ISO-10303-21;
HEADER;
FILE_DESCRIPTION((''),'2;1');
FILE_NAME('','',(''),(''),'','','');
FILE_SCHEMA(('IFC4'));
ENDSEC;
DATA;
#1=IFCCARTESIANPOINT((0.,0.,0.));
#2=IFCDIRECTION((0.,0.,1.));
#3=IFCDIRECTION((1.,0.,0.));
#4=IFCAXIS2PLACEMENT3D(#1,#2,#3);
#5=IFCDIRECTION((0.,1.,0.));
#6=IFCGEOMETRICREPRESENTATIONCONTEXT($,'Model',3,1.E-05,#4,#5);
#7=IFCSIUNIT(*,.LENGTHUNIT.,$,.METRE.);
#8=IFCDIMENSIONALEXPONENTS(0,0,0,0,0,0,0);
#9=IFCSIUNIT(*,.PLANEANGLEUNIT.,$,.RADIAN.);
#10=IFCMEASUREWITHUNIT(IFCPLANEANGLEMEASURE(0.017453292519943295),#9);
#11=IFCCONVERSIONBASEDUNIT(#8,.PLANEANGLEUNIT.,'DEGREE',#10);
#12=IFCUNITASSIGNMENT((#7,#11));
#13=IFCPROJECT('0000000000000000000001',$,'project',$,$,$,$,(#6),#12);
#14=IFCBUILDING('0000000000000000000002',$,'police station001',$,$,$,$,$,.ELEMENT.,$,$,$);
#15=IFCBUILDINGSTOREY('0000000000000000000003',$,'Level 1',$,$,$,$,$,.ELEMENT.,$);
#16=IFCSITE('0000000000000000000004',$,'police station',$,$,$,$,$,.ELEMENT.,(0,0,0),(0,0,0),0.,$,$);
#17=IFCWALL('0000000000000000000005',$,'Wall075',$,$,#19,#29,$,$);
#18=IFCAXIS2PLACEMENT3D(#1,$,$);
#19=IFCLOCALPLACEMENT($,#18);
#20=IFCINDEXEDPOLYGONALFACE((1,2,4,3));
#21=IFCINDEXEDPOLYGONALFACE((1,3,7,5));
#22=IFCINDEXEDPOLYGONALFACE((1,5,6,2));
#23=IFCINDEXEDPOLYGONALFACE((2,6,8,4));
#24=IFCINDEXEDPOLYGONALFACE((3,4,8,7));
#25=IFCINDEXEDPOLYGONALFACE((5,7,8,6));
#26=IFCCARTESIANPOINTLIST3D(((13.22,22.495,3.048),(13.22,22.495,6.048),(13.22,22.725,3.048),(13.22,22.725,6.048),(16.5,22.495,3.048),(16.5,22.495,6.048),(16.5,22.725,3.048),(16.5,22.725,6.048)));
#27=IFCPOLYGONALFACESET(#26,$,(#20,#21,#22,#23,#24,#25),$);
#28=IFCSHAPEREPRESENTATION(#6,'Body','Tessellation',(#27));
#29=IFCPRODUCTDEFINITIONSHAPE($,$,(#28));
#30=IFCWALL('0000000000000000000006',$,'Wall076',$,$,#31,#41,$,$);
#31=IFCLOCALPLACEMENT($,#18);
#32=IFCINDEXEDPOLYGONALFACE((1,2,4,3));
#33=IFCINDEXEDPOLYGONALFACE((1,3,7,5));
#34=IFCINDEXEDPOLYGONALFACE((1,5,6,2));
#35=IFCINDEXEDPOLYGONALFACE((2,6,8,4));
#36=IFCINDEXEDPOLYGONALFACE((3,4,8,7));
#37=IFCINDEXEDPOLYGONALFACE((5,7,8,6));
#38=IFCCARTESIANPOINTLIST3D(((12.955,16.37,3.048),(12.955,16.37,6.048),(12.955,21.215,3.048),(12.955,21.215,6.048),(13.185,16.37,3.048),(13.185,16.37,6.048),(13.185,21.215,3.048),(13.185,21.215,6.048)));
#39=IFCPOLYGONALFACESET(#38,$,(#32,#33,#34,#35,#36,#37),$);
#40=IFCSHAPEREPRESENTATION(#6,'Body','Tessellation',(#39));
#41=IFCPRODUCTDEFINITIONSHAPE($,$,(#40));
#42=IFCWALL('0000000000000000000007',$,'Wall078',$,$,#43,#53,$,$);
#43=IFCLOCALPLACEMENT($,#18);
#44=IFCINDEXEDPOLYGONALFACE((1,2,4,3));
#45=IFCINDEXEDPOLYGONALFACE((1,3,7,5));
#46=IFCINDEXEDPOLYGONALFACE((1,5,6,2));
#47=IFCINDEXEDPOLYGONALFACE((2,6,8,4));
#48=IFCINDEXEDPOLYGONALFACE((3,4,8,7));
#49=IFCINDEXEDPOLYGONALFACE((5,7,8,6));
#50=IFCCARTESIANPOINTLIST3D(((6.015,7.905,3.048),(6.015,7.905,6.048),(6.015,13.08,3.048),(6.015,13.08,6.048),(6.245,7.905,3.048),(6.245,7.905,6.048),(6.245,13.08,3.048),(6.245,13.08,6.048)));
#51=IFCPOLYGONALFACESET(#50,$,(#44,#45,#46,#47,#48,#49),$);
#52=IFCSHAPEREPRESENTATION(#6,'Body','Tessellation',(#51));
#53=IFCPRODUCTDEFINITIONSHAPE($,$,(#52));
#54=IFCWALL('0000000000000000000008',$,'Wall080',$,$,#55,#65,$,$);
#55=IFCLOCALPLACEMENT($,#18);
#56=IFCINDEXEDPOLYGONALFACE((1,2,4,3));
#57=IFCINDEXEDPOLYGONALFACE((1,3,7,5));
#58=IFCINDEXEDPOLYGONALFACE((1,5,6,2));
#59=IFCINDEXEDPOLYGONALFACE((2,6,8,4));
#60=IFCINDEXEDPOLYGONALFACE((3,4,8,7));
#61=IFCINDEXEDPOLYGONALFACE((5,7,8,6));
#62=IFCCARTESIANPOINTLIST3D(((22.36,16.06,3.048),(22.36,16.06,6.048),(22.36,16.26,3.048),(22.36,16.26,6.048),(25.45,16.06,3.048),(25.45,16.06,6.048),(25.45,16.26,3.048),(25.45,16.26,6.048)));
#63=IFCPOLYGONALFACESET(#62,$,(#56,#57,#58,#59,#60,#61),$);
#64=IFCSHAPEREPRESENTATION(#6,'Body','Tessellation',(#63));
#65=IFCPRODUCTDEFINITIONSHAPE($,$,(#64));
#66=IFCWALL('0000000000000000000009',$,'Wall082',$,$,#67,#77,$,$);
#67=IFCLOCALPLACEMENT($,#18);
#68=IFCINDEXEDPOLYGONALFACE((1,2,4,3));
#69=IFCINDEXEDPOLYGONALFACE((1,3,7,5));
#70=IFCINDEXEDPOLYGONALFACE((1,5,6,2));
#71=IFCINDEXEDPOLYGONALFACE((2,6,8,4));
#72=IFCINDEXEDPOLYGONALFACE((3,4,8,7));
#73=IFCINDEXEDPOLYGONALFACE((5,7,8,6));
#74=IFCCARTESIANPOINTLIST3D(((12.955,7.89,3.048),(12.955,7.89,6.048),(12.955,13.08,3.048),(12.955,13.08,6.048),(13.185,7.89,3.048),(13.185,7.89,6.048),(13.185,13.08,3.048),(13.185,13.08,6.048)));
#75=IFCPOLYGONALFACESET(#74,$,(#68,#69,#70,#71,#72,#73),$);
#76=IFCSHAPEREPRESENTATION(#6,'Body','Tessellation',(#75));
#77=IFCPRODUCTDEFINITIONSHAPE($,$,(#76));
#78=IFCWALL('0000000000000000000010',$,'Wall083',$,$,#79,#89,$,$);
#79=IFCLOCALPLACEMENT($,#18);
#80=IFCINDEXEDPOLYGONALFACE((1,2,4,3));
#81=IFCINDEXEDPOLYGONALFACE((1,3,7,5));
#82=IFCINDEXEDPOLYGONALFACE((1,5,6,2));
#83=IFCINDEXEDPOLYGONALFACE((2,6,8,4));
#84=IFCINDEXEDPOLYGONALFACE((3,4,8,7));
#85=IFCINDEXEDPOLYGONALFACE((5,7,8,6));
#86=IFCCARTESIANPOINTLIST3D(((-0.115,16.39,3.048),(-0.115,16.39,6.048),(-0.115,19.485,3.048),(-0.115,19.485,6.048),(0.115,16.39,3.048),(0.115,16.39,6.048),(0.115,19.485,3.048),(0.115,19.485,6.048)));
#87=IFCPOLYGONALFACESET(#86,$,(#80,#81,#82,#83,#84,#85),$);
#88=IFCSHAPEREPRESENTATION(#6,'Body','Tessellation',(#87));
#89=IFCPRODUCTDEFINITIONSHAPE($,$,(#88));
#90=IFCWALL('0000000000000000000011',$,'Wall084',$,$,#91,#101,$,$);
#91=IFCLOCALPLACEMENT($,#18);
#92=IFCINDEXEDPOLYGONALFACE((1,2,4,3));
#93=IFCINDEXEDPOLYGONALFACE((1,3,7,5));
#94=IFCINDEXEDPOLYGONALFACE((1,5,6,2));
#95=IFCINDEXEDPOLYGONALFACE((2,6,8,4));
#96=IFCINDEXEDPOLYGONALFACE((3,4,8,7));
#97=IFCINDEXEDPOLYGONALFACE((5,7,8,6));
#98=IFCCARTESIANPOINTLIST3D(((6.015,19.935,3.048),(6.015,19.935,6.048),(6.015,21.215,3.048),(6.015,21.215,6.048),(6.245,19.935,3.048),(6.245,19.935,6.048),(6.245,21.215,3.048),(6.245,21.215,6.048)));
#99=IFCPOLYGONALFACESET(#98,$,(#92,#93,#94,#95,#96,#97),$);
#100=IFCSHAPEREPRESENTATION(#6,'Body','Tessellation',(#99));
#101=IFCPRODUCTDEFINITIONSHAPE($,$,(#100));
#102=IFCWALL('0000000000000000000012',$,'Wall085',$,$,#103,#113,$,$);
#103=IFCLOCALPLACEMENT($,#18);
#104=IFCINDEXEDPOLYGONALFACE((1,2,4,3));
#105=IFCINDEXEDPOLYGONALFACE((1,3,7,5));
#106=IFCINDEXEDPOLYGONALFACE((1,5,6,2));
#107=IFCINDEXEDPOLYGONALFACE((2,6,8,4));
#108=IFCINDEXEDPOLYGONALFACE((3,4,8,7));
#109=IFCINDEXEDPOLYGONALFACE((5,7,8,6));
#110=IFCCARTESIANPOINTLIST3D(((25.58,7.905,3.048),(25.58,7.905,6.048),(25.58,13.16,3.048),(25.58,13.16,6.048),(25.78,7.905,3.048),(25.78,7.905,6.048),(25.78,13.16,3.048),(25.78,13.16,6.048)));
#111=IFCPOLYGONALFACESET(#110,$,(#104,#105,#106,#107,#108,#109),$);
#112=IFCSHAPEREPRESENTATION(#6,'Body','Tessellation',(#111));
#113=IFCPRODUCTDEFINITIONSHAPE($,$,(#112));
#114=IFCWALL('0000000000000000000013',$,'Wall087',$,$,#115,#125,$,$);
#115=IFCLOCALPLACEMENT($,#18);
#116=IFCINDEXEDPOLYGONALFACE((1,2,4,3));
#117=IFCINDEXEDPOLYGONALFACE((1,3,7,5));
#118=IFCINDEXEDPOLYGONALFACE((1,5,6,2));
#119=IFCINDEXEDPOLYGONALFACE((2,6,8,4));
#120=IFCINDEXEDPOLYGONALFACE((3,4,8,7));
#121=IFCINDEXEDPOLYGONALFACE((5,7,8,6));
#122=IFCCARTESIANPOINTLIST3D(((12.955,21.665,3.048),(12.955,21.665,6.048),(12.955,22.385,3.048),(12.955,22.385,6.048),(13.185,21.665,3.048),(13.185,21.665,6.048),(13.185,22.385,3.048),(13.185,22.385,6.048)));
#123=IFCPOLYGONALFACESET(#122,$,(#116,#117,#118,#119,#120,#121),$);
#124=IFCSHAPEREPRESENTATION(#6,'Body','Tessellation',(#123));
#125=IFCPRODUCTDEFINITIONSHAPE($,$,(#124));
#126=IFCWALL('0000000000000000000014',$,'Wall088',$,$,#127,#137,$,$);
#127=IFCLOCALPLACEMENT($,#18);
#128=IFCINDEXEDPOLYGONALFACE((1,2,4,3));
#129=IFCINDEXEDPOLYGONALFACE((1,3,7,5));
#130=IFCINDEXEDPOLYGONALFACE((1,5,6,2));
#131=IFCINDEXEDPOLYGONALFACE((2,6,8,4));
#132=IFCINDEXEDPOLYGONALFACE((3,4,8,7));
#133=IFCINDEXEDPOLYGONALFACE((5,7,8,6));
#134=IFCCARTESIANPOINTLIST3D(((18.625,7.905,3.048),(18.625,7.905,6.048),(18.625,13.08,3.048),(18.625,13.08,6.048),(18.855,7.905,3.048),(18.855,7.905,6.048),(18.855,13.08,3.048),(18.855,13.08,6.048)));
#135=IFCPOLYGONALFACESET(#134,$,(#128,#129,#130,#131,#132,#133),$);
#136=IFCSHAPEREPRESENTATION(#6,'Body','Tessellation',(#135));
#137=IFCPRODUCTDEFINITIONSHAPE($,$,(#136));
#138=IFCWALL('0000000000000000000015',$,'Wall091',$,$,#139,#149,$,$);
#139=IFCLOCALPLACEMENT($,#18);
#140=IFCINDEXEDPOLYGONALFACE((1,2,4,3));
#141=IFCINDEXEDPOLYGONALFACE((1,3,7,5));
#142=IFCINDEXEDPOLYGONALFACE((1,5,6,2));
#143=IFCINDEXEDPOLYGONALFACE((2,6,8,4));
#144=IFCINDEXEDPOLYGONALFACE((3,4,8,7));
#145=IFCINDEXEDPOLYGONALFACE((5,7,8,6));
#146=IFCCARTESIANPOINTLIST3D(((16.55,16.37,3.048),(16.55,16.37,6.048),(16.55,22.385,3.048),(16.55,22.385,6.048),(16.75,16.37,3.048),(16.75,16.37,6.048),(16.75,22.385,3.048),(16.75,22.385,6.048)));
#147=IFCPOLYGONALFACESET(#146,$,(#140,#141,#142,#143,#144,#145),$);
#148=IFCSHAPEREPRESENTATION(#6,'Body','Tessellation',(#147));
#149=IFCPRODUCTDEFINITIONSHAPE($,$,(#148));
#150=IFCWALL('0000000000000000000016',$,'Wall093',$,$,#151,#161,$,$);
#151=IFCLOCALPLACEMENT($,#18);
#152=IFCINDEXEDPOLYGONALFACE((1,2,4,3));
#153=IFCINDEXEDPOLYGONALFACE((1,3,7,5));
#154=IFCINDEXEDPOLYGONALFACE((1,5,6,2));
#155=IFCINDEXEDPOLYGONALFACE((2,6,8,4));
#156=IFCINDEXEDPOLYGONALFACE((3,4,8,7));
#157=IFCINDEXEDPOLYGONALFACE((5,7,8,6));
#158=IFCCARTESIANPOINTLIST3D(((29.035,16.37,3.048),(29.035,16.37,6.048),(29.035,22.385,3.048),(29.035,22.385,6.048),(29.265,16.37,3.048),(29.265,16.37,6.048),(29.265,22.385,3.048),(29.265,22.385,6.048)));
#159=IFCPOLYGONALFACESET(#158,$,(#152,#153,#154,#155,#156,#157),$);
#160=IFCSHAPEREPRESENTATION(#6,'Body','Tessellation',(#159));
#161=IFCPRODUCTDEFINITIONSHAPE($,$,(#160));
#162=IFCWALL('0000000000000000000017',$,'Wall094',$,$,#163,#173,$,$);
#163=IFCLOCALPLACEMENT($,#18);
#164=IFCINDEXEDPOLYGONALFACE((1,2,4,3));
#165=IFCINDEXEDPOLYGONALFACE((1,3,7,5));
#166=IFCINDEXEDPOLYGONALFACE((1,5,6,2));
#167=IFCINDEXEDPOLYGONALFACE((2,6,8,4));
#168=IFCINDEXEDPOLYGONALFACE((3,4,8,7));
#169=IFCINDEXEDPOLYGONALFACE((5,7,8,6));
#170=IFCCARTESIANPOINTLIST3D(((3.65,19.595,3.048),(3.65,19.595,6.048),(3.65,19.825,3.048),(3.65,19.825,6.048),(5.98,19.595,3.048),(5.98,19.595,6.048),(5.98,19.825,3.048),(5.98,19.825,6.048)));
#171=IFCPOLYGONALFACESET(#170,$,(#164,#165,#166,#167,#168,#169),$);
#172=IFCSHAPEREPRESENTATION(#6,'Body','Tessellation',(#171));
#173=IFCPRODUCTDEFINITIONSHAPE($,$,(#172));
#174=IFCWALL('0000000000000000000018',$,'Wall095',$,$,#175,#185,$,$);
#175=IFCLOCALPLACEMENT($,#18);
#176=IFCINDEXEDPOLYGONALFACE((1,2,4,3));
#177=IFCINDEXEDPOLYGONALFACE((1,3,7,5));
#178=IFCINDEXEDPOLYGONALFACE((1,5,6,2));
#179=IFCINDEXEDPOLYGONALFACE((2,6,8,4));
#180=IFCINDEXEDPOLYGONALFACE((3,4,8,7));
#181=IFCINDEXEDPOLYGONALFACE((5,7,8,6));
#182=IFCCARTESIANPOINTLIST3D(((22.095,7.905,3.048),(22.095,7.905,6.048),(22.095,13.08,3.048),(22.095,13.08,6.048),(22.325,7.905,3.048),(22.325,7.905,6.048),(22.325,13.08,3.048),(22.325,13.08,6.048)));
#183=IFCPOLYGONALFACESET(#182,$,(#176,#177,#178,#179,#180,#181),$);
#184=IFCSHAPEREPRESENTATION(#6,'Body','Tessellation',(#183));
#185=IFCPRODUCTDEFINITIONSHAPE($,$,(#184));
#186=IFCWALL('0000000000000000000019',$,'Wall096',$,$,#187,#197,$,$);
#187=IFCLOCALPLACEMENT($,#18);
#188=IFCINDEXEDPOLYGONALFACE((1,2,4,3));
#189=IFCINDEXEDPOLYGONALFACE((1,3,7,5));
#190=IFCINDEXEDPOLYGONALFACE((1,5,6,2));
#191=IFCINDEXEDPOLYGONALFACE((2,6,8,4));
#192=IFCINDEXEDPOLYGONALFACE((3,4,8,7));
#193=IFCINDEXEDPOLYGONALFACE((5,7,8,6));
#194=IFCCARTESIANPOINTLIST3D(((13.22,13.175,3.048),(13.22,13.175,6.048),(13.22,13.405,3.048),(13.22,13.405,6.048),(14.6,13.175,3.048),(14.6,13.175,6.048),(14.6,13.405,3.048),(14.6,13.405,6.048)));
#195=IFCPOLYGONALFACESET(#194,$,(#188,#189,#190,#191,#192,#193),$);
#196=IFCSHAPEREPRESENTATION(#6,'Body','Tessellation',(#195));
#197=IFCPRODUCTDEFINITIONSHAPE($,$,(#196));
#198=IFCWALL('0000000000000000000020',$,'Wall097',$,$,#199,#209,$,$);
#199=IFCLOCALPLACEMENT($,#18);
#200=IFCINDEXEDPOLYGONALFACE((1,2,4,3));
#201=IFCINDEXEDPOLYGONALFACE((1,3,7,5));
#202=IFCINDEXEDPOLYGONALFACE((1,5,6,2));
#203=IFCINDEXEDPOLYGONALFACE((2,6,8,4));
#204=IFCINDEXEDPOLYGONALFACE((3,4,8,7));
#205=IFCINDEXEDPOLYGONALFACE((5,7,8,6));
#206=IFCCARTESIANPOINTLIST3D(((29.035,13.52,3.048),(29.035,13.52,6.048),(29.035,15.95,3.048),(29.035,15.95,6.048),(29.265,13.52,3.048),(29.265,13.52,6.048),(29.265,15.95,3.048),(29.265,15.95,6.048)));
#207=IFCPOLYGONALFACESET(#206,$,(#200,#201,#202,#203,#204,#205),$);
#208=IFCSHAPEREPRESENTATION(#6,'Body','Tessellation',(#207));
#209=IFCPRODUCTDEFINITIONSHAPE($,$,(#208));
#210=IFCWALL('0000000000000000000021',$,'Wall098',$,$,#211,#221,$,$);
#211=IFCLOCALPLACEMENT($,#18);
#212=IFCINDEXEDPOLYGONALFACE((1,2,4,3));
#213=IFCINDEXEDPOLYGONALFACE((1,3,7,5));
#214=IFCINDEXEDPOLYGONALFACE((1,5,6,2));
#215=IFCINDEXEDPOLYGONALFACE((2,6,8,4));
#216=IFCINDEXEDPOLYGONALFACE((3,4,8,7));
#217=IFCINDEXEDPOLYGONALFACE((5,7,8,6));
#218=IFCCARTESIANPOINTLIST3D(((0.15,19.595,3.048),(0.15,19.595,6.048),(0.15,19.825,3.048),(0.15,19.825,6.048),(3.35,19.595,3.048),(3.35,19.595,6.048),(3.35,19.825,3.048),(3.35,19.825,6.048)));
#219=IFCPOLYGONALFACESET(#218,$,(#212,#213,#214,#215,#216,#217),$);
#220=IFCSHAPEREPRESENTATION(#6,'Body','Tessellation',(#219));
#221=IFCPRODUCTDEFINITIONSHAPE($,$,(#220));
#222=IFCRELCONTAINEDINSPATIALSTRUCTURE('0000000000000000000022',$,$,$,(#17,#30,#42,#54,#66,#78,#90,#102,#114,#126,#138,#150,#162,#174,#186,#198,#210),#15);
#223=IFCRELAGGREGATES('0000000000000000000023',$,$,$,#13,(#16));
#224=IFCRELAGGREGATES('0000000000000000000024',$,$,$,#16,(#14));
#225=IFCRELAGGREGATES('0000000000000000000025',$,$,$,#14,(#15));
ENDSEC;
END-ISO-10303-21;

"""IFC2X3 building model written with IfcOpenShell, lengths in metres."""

from ifc_helpers import new_model, entity, si_unit, converted_unit, direction, frame, frame_2d, origin_with_axes, place, context, project, spatial, rectangle, extrude, element, save


model = new_model("IFC2X3")

# Units and contexts
model_context = context("Model", 3, precision=1e-05, world=origin_with_axes(), true_north=direction((0.0, 1.0, 0.0)))
ifc_project = project(units=[si_unit("LENGTHUNIT", "METRE"), converted_unit("PLANEANGLEUNIT", "DEGREE", entity("IfcPlaneAngleMeasure", 0.017453292519943295), si_unit("PLANEANGLEUNIT", "RADIAN"), dimensions=[0, 0, 0, 0, 0, 0, 0])], contexts=[model_context])

# Site, building, storey
site = spatial("IfcSite", under=ifc_project, Name="police station", CompositionType="ELEMENT", RefLatitude=(0, 0, 0), RefLongitude=(0, 0, 0), RefElevation=0.0)
building = spatial("IfcBuilding", under=site, Name="police station001", CompositionType="ELEMENT")
storey = spatial("IfcBuildingStorey", under=building, Name="Level 1", CompositionType="ELEMENT")

# Shared definitions
placement = place(None, origin_with_axes())

# Walls
element("IfcWall", 1, at=placement, inside=storey, Name="Wall075", context=model_context, shape_type="SweptSolid", body=[
    extrude(rectangle(XDim=3.28, YDim=0.23, at=frame_2d((0.0, 0.0), x_axis=(-1.0, 0.0, 0.0))), frame((14.86, 22.61, 3.048), z_axis=(0.0, 0.0, 1.0), x_axis=(1.0, 0.0, 0.0)), (0.0, 0.0, 1.0), 3.0),
])
element("IfcWall", 2, at=placement, inside=storey, Name="Wall076", context=model_context, shape_type="SweptSolid", body=[
    extrude(rectangle(XDim=4.845, YDim=0.23, at=frame_2d((0.0, 0.0), x_axis=(0.0, -1.0, 0.0))), frame((13.07, 18.7925, 3.048), z_axis=(0.0, 0.0, 1.0), x_axis=(1.0, 0.0, 0.0)), (0.0, 0.0, 1.0), 3.0),
])
element("IfcWall", 3, at=placement, inside=storey, Name="Wall078", context=model_context, shape_type="SweptSolid", body=[
    extrude(rectangle(XDim=5.175, YDim=0.23, at=frame_2d((0.0, 0.0), x_axis=(0.0, -1.0, 0.0))), frame((6.13, 10.4925, 3.048), z_axis=(0.0, 0.0, 1.0), x_axis=(1.0, 0.0, 0.0)), (0.0, 0.0, 1.0), 3.0),
])
element("IfcWall", 4, at=placement, inside=storey, Name="Wall080", context=model_context, shape_type="SweptSolid", body=[
    extrude(rectangle(XDim=3.09, YDim=0.2, at=frame_2d((0.0, 0.0), x_axis=(1.0, 0.0, 0.0))), frame((23.905, 16.16, 3.048), z_axis=(0.0, 0.0, 1.0), x_axis=(1.0, 0.0, 0.0)), (0.0, 0.0, 1.0), 3.0),
])
element("IfcWall", 5, at=placement, inside=storey, Name="Wall082", context=model_context, shape_type="SweptSolid", body=[
    extrude(rectangle(XDim=5.19, YDim=0.23, at=frame_2d((0.0, 0.0), x_axis=(0.0, 1.0, 0.0))), frame((13.07, 10.485, 3.048), z_axis=(0.0, 0.0, 1.0), x_axis=(1.0, 0.0, 0.0)), (0.0, 0.0, 1.0), 3.0),
])
element("IfcWall", 6, at=placement, inside=storey, Name="Wall083", context=model_context, shape_type="SweptSolid", body=[
    extrude(rectangle(XDim=3.095, YDim=0.23, at=frame_2d((0.0, 0.0), x_axis=(0.0, -1.0, 0.0))), frame((0.0, 17.9375, 3.048), z_axis=(0.0, 0.0, 1.0), x_axis=(1.0, 0.0, 0.0)), (0.0, 0.0, 1.0), 3.0),
])
element("IfcWall", 7, at=placement, inside=storey, Name="Wall084", context=model_context, shape_type="SweptSolid", body=[
    extrude(rectangle(XDim=1.28, YDim=0.23, at=frame_2d((0.0, 0.0), x_axis=(0.0, -1.0, 0.0))), frame((6.13, 20.575, 3.048), z_axis=(0.0, 0.0, 1.0), x_axis=(1.0, 0.0, 0.0)), (0.0, 0.0, 1.0), 3.0),
])
element("IfcWall", 8, at=placement, inside=storey, Name="Wall085", context=model_context, shape_type="SweptSolid", body=[
    extrude(rectangle(XDim=5.255, YDim=0.2, at=frame_2d((0.0, 0.0), x_axis=(0.0, -1.0, 0.0))), frame((25.68, 10.5325, 3.048), z_axis=(0.0, 0.0, 1.0), x_axis=(1.0, 0.0, 0.0)), (0.0, 0.0, 1.0), 3.0),
])
element("IfcWall", 9, at=placement, inside=storey, Name="Wall087", context=model_context, shape_type="SweptSolid", body=[
    extrude(rectangle(XDim=0.72, YDim=0.23, at=frame_2d((0.0, 0.0), x_axis=(0.0, 1.0, 0.0))), frame((13.07, 22.025, 3.048), z_axis=(0.0, 0.0, 1.0), x_axis=(1.0, 0.0, 0.0)), (0.0, 0.0, 1.0), 3.0),
])
element("IfcWall", 10, at=placement, inside=storey, Name="Wall088", context=model_context, shape_type="SweptSolid", body=[
    extrude(rectangle(XDim=5.175, YDim=0.23, at=frame_2d((0.0, 0.0), x_axis=(0.0, 1.0, 0.0))), frame((18.74, 10.4925, 3.048), z_axis=(0.0, 0.0, 1.0), x_axis=(1.0, 0.0, 0.0)), (0.0, 0.0, 1.0), 3.0),
])
element("IfcWall", 11, at=placement, inside=storey, Name="Wall091", context=model_context, shape_type="SweptSolid", body=[
    extrude(rectangle(XDim=6.015, YDim=0.2, at=frame_2d((0.0, 0.0), x_axis=(0.0, -1.0, 0.0))), frame((16.65, 19.3775, 3.048), z_axis=(0.0, 0.0, 1.0), x_axis=(1.0, 0.0, 0.0)), (0.0, 0.0, 1.0), 3.0),
])
element("IfcWall", 12, at=placement, inside=storey, Name="Wall093", context=model_context, shape_type="SweptSolid", body=[
    extrude(rectangle(XDim=6.015, YDim=0.23, at=frame_2d((0.0, 0.0), x_axis=(0.0, 1.0, 0.0))), frame((29.15, 19.3775, 3.048), z_axis=(0.0, 0.0, 1.0), x_axis=(1.0, 0.0, 0.0)), (0.0, 0.0, 1.0), 3.0),
])
element("IfcWall", 13, at=placement, inside=storey, Name="Wall094", context=model_context, shape_type="SweptSolid", body=[
    extrude(rectangle(XDim=2.33, YDim=0.23, at=frame_2d((0.0, 0.0), x_axis=(1.0, 0.0, 0.0))), frame((4.815, 19.71, 3.048), z_axis=(0.0, 0.0, 1.0), x_axis=(1.0, 0.0, 0.0)), (0.0, 0.0, 1.0), 3.0),
])
element("IfcWall", 14, at=placement, inside=storey, Name="Wall095", context=model_context, shape_type="SweptSolid", body=[
    extrude(rectangle(XDim=5.175, YDim=0.23, at=frame_2d((0.0, 0.0), x_axis=(0.0, -1.0, 0.0))), frame((22.21, 10.4925, 3.048), z_axis=(0.0, 0.0, 1.0), x_axis=(1.0, 0.0, 0.0)), (0.0, 0.0, 1.0), 3.0),
])
element("IfcWall", 15, at=placement, inside=storey, Name="Wall096", context=model_context, shape_type="SweptSolid", body=[
    extrude(rectangle(XDim=1.38, YDim=0.23, at=frame_2d((0.0, 0.0), x_axis=(1.0, 0.0, 0.0))), frame((13.91, 13.29, 3.048), z_axis=(0.0, 0.0, 1.0), x_axis=(1.0, 0.0, 0.0)), (0.0, 0.0, 1.0), 3.0),
])
element("IfcWall", 16, at=placement, inside=storey, Name="Wall097", context=model_context, shape_type="SweptSolid", body=[
    extrude(rectangle(XDim=2.43, YDim=0.23, at=frame_2d((0.0, 0.0), x_axis=(0.0, -1.0, 0.0))), frame((29.15, 14.735, 3.048), z_axis=(0.0, 0.0, 1.0), x_axis=(1.0, 0.0, 0.0)), (0.0, 0.0, 1.0), 3.0),
])
element("IfcWall", 17, at=placement, inside=storey, Name="Wall098", context=model_context, shape_type="SweptSolid", body=[
    extrude(rectangle(XDim=3.2, YDim=0.23, at=frame_2d((0.0, 0.0), x_axis=(1.0, 0.0, 0.0))), frame((1.75, 19.71, 3.048), z_axis=(0.0, 0.0, 1.0), x_axis=(1.0, 0.0, 0.0)), (0.0, 0.0, 1.0), 3.0),
])

save(model, "model.ifc")
